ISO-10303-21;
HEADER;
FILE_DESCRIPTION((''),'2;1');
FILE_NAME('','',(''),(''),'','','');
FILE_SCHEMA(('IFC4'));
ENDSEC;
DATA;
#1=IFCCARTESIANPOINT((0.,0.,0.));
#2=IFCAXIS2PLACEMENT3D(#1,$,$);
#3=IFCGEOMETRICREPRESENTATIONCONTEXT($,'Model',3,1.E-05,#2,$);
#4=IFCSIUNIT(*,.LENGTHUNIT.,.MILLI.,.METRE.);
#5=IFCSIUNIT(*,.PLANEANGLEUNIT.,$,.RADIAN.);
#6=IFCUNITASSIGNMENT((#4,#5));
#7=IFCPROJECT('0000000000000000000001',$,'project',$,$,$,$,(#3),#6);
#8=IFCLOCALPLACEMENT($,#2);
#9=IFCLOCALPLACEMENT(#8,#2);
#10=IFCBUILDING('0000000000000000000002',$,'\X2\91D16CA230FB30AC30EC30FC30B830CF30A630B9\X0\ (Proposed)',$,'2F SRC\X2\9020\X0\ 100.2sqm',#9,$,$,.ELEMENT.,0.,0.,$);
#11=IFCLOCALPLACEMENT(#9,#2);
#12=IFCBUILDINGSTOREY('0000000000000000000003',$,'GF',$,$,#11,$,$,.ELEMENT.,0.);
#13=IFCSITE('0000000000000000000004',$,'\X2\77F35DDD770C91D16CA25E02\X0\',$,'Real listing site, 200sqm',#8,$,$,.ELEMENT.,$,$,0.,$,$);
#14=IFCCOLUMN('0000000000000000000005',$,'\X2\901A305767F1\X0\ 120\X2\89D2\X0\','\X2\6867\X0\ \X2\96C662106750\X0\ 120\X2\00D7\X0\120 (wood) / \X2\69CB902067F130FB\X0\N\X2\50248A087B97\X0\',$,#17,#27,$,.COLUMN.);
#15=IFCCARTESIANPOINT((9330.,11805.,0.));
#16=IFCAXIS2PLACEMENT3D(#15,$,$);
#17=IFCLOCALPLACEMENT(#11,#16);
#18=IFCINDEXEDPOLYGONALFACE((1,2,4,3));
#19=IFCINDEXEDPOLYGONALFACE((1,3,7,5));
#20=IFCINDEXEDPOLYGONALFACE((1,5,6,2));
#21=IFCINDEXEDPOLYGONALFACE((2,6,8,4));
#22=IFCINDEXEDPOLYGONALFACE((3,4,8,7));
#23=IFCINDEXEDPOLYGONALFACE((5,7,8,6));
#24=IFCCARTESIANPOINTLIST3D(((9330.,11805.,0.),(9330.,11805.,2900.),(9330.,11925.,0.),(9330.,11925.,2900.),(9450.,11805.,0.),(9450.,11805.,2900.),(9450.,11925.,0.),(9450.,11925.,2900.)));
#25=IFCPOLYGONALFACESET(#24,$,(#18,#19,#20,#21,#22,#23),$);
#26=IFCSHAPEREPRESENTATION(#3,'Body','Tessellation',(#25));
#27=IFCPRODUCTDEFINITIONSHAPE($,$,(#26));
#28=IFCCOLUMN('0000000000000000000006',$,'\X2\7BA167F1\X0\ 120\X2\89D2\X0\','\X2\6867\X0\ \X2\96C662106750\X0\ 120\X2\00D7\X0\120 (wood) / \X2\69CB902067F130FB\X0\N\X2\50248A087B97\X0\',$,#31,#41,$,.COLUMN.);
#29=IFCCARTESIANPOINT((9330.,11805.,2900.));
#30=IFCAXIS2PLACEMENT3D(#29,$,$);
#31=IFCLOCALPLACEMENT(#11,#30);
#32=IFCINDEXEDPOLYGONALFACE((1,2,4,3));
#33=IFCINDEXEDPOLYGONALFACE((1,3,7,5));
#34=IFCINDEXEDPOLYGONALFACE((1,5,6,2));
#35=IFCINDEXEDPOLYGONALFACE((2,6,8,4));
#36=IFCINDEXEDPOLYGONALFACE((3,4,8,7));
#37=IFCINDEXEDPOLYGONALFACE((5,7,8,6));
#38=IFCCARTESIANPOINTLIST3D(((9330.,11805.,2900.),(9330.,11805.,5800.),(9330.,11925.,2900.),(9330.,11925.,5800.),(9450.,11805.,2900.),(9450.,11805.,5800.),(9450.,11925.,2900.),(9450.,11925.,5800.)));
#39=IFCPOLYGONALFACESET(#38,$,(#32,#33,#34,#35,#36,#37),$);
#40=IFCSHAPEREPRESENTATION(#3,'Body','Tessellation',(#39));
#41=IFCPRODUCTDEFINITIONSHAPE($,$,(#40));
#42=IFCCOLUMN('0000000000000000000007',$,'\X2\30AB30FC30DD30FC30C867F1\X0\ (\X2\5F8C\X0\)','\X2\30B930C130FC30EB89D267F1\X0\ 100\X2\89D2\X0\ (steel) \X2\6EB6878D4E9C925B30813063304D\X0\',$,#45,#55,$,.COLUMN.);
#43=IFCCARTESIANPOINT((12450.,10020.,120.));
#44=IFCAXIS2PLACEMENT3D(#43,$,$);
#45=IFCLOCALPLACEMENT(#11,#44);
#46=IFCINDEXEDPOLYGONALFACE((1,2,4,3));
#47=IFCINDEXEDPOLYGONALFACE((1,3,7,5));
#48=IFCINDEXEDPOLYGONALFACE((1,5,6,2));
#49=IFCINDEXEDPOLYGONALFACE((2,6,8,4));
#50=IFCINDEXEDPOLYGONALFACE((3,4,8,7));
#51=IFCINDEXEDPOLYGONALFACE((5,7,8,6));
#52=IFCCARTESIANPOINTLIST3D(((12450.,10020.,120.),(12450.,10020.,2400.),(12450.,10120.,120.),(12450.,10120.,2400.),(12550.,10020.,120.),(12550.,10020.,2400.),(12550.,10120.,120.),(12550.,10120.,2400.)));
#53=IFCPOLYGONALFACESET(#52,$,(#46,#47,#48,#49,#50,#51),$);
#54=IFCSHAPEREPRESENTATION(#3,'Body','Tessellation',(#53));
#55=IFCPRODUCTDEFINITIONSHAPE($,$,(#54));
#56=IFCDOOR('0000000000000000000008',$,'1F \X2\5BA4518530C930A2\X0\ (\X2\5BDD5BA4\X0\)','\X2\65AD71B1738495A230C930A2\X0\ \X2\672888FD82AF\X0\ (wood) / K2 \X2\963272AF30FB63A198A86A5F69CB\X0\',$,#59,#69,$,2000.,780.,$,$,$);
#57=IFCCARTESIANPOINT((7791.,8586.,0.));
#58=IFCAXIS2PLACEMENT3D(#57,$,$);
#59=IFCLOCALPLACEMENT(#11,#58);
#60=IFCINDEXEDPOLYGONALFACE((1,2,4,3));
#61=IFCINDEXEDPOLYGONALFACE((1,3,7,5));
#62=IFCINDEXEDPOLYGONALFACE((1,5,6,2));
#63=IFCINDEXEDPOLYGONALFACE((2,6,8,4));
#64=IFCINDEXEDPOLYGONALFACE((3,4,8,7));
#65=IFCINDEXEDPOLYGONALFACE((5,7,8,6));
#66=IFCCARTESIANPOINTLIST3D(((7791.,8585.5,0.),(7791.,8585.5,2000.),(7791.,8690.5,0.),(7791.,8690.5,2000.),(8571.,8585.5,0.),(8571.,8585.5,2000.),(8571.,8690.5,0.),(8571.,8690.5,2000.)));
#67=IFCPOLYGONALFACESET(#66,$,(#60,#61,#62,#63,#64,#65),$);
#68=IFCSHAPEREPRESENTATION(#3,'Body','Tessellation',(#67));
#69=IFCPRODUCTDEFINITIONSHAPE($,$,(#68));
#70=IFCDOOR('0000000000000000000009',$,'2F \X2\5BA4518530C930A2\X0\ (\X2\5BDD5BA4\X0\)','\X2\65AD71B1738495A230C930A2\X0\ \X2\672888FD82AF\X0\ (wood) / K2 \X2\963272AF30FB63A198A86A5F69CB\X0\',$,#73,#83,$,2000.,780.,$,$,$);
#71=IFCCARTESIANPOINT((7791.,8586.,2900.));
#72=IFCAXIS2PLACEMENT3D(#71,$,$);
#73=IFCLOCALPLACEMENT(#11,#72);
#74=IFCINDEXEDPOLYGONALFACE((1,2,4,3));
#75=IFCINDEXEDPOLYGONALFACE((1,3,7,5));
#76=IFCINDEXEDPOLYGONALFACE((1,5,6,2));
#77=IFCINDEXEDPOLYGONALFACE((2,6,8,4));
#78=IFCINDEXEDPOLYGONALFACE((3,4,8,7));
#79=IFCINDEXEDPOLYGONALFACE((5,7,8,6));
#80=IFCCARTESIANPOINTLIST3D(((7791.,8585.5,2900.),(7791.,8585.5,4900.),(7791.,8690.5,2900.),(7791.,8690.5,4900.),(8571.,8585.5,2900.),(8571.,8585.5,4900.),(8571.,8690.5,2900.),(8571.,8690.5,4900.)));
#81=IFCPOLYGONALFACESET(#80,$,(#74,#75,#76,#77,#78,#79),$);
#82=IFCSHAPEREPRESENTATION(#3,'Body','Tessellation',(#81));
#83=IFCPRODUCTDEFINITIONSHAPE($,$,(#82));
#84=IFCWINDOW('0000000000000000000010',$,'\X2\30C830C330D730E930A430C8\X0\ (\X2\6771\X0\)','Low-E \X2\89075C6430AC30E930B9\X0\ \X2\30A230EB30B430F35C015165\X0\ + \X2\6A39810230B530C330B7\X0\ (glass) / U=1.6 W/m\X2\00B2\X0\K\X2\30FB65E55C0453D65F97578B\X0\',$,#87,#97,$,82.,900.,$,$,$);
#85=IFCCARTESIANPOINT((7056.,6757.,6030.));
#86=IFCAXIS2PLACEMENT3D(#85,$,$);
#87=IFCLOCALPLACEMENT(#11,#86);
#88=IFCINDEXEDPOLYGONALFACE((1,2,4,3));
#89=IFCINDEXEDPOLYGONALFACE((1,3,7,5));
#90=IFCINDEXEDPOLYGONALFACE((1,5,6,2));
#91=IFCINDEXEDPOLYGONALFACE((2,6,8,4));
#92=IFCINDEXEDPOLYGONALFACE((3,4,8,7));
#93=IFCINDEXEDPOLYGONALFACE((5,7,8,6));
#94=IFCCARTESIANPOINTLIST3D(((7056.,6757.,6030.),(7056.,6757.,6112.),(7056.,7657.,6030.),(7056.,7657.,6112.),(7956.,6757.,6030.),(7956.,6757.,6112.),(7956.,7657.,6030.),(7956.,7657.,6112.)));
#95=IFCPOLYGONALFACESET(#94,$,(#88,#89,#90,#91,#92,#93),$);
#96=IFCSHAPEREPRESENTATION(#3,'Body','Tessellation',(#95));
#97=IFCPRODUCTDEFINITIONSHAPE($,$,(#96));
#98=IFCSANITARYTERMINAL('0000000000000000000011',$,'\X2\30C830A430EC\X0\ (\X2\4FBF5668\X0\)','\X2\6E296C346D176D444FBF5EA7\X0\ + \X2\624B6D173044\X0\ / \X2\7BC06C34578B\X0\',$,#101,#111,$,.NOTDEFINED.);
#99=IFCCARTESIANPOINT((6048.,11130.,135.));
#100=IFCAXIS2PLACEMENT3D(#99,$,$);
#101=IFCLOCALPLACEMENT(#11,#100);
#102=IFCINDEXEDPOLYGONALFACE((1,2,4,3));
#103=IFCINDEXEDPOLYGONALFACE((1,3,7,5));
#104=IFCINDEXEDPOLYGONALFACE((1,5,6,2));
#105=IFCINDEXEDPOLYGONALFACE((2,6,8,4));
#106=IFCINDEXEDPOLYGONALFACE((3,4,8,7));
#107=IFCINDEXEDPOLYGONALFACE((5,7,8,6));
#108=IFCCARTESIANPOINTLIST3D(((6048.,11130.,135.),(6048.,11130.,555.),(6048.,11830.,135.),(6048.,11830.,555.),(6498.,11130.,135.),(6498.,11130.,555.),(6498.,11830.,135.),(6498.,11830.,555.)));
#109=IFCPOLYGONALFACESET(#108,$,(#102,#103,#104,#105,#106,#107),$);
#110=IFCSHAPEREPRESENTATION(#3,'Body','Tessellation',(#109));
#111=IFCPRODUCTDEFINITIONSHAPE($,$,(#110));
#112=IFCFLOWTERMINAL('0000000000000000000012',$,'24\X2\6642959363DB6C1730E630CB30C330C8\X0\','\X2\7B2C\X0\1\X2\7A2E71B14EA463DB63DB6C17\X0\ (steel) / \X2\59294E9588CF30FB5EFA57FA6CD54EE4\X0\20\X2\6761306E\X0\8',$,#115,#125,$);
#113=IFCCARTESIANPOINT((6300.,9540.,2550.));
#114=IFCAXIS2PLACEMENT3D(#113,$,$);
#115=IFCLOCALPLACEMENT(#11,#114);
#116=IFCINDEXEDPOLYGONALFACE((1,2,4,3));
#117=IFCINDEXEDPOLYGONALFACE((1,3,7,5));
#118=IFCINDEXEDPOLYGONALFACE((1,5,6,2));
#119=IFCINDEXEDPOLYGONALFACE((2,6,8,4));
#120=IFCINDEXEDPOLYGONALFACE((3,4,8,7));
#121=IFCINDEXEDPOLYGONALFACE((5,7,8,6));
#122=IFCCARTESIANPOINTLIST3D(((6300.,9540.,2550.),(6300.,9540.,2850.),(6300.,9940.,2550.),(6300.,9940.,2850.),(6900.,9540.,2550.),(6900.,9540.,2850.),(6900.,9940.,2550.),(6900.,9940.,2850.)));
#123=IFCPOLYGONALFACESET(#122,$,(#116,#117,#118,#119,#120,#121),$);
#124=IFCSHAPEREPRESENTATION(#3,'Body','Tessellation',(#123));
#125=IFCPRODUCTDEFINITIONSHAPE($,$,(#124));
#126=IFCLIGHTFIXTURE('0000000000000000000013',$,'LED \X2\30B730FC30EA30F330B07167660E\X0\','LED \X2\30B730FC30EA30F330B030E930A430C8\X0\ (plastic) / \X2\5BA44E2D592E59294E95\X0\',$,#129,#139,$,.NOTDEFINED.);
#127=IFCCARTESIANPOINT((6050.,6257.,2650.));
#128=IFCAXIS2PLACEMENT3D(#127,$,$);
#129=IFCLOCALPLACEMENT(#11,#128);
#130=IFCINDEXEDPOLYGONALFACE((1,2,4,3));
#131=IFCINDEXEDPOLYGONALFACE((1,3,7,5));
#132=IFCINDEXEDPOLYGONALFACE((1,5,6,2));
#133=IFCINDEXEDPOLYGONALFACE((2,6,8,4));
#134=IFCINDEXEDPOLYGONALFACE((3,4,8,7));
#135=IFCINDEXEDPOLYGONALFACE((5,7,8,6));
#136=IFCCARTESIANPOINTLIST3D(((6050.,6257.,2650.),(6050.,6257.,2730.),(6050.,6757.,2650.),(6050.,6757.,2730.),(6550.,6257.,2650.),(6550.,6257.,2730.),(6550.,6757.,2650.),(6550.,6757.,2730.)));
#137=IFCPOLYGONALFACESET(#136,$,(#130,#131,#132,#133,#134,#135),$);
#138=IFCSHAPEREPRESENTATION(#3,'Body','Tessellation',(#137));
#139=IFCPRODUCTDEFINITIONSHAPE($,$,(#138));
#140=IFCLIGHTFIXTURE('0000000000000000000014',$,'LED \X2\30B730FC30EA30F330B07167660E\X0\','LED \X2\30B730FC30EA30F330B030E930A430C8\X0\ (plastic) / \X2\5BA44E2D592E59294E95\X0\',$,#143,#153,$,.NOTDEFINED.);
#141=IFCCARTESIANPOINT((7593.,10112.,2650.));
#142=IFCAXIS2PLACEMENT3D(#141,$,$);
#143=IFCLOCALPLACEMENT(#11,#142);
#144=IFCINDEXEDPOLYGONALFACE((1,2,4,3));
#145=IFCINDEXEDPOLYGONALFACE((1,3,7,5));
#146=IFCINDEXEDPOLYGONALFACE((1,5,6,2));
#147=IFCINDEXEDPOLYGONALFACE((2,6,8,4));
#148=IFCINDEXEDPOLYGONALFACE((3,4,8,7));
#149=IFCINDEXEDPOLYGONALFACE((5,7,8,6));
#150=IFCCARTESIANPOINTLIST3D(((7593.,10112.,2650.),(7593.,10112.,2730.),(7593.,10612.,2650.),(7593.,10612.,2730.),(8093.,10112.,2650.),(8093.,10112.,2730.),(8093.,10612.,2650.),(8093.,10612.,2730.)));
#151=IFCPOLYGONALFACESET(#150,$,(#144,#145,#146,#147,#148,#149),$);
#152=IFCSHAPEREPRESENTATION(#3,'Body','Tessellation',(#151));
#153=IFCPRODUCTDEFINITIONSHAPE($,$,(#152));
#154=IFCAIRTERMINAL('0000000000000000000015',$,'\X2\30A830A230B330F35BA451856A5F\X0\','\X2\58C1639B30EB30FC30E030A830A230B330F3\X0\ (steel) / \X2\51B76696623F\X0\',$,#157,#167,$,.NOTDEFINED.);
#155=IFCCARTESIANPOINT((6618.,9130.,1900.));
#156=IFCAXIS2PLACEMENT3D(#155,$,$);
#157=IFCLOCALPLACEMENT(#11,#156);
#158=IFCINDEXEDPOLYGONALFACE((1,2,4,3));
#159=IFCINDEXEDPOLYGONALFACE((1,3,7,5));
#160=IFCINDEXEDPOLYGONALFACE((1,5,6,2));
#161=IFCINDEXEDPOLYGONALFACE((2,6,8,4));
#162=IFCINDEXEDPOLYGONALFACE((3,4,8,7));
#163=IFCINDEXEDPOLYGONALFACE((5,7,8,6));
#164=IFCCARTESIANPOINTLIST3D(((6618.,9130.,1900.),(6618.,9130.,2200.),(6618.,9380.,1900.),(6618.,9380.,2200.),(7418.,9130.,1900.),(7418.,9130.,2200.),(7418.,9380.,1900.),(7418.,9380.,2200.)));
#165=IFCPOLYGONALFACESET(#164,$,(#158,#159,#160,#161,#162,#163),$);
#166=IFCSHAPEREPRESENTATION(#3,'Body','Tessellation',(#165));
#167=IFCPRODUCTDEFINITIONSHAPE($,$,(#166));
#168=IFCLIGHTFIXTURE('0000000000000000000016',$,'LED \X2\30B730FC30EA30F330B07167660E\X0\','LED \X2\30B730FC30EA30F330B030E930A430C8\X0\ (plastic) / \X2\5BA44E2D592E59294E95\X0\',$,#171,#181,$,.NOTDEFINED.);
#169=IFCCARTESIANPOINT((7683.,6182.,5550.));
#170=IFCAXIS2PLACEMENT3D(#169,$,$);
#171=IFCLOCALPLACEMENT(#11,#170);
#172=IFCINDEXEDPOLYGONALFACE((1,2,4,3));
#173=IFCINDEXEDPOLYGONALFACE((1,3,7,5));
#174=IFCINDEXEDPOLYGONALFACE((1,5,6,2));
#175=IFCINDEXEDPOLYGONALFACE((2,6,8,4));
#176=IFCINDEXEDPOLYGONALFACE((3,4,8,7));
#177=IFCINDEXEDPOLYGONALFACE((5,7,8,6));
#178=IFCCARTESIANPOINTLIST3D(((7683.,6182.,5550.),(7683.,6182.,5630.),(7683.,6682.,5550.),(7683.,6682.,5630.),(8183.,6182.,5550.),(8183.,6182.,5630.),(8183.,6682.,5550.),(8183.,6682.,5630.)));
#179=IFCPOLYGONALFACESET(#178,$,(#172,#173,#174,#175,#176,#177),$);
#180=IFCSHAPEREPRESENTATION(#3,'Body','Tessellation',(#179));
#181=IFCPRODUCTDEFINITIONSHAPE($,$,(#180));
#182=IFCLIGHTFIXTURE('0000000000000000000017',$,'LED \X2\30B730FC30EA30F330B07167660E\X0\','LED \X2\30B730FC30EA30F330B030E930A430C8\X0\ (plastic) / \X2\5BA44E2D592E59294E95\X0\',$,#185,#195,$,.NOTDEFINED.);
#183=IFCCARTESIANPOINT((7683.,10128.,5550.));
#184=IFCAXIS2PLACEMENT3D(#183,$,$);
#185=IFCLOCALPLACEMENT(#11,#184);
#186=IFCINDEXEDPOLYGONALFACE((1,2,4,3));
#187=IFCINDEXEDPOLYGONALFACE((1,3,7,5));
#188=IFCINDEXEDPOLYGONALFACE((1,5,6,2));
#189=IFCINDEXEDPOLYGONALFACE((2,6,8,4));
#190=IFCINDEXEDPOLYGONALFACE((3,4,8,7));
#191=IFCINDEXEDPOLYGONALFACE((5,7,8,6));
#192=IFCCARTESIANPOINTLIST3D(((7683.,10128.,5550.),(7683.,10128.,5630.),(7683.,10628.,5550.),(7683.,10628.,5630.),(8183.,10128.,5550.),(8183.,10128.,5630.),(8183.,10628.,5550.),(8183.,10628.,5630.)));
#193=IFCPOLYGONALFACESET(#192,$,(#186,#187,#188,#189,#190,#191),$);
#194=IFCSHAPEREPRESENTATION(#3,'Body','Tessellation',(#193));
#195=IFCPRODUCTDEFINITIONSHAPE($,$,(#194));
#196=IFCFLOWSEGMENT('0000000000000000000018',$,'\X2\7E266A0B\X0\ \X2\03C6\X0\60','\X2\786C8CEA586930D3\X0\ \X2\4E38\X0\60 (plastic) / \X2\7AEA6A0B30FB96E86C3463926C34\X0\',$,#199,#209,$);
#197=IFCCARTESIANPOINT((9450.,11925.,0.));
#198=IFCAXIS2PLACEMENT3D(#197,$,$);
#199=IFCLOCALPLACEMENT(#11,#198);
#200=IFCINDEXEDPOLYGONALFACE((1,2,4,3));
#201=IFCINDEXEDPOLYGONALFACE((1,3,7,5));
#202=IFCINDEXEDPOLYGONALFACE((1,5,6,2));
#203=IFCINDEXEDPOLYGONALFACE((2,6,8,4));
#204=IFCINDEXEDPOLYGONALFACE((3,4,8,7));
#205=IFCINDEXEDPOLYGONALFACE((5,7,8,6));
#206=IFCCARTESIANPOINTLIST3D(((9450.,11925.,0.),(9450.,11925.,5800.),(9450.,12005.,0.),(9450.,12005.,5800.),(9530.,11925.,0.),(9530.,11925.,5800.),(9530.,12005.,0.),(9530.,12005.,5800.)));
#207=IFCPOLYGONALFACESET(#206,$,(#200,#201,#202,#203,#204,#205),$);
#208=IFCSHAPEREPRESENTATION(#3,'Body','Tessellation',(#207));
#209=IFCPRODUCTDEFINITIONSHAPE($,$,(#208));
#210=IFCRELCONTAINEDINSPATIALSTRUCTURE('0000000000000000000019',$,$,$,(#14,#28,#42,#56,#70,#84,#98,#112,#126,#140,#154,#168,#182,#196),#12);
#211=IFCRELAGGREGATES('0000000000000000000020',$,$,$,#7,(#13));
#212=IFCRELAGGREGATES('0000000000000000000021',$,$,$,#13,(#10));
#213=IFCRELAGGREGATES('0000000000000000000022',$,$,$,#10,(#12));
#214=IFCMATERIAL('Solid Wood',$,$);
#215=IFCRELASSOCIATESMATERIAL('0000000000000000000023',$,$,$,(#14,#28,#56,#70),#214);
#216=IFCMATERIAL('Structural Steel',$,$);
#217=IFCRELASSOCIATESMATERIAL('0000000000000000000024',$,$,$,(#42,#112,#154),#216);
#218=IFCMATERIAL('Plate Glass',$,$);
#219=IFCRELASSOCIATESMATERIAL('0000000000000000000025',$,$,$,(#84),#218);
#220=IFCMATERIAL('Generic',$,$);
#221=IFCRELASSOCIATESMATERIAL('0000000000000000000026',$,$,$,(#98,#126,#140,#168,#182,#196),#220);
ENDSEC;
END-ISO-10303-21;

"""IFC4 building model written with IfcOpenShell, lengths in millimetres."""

from ifc_helpers import new_model, si_unit, frame, frame_2d, origin, place, context, project, spatial, rectangle, extrude, material, element, save


model = new_model("IFC4")

# Units and contexts
model_context = context("Model", 3, precision=1e-05, world=origin())
ifc_project = project(units=[si_unit("LENGTHUNIT", "METRE", prefix="MILLI"), si_unit("PLANEANGLEUNIT", "RADIAN")], contexts=[model_context])

# Site, building, storey
site_placement = place(None, origin())
site = spatial("IfcSite", under=ifc_project, at=site_placement, Name="石川県金沢市", ObjectType="Real listing site, 200sqm", CompositionType="ELEMENT", RefElevation=0.0)
building_placement = place(site_placement, origin())
building = spatial("IfcBuilding", under=site, at=building_placement, Name="金沢・ガレージハウス (Proposed)", ObjectType="2F SRC造 100.2sqm", CompositionType="ELEMENT", ElevationOfRefHeight=0.0, ElevationOfTerrain=0.0)
storey_placement = place(building_placement, origin())
storey = spatial("IfcBuildingStorey", under=building, at=storey_placement, Name="GF", CompositionType="ELEMENT", Elevation=0.0)

# Columns
ifc_material_1 = material(Name="Solid Wood")
column_1_placement = place(storey_placement, frame((9330.0, 11805.0, 0.0)))
element("IfcColumn", 1, at=column_1_placement, inside=storey, material=ifc_material_1, Name="通し柱 120角", Description="桧 集成材 120×120 (wood) / 構造柱・N値計算", PredefinedType="COLUMN", context=model_context, shape_type="SweptSolid", body=[
    extrude(rectangle(XDim=120.0, YDim=120.0, at=frame_2d((60.0, 60.0))), frame((9330.0, 11805.0, 0.0)), (0.0, 0.0, 1.0), 2900.0),
])
column_2_placement = place(storey_placement, frame((9330.0, 11805.0, 2900.0)))
element("IfcColumn", 2, at=column_2_placement, inside=storey, material=ifc_material_1, Name="管柱 120角", Description="桧 集成材 120×120 (wood) / 構造柱・N値計算", PredefinedType="COLUMN", context=model_context, shape_type="SweptSolid", body=[
    extrude(rectangle(XDim=120.0, YDim=120.0, at=frame_2d((60.0, 60.0))), frame((9330.0, 11805.0, 2900.0)), (0.0, 0.0, 1.0), 2900.0),
])
ifc_material_2 = material(Name="Structural Steel")
column_3_placement = place(storey_placement, frame((12450.0, 10020.0, 120.0)))
element("IfcColumn", 3, at=column_3_placement, inside=storey, material=ifc_material_2, Name="カーポート柱 (後)", Description="スチール角柱 100角 (steel) 溶融亜鉛めっき", PredefinedType="COLUMN", context=model_context, shape_type="SweptSolid", body=[
    extrude(rectangle(XDim=100.0, YDim=100.0, at=frame_2d((50.0, 50.0))), frame((12450.0, 10020.0, 120.0)), (0.0, 0.0, 1.0), 2280.0),
])

# Door
door_1_placement = place(storey_placement, frame((7791.0, 8586.0, 0.0)))
element("IfcDoor", 4, at=door_1_placement, inside=storey, material=ifc_material_1, Name="1F 室内ドア (寝室)", Description="断熱玄関ドア 木製芯 (wood) / K2 防犯・採風機構", OverallHeight=2000.0, OverallWidth=780.0, context=model_context, shape_type="SweptSolid", body=[
    extrude(rectangle(XDim=780.0, YDim=105.0, at=frame_2d((390.0, 52.0))), frame((7791.0, 8586.0, 0.0)), (0.0, 0.0, 1.0), 2000.0),
])

# Door
door_2_placement = place(storey_placement, frame((7791.0, 8586.0, 2900.0)))
element("IfcDoor", 5, at=door_2_placement, inside=storey, material=ifc_material_1, Name="2F 室内ドア (寝室)", Description="断熱玄関ドア 木製芯 (wood) / K2 防犯・採風機構", OverallHeight=2000.0, OverallWidth=780.0, context=model_context, shape_type="SweptSolid", body=[
    extrude(rectangle(XDim=780.0, YDim=105.0, at=frame_2d((390.0, 52.0))), frame((7791.0, 8586.0, 2900.0)), (0.0, 0.0, 1.0), 2000.0),
])

# Window
ifc_material_3 = material(Name="Plate Glass")
window_placement = place(storey_placement, frame((7056.0, 6757.0, 6030.0)))
element("IfcWindow", 6, at=window_placement, inside=storey, material=ifc_material_3, Name="トップライト (東)", Description="Low-E 複層ガラス アルゴン封入 + 樹脂サッシ (glass) / U=1.6 W/m²K・日射取得型", OverallHeight=82.0, OverallWidth=900.0, context=model_context, shape_type="SweptSolid", body=[
    extrude(rectangle(XDim=900.0, YDim=900.0, at=frame_2d((450.0, 450.0))), frame((7056.0, 6757.0, 6030.0)), (0.0, 0.0, 1.0), 82.0),
])

# Sanitary terminal
ifc_material_4 = material(Name="Generic")
sanitary_terminal_placement = place(storey_placement, frame((6048.0, 11130.0, 135.0)))
element("IfcSanitaryTerminal", 7, at=sanitary_terminal_placement, inside=storey, material=ifc_material_4, Name="トイレ (便器)", Description="温水洗浄便座 + 手洗い / 節水型", PredefinedType="NOTDEFINED", context=model_context, shape_type="SweptSolid", body=[
    extrude(rectangle(XDim=450.0, YDim=700.0, at=frame_2d((225.0, 350.0))), frame((6048.0, 11130.0, 135.0)), (0.0, 0.0, 1.0), 420.0),
])

# Flow terminal
flow_terminal_placement = place(storey_placement, frame((6300.0, 9540.0, 2550.0)))
element("IfcFlowTerminal", 8, at=flow_terminal_placement, inside=storey, material=ifc_material_2, Name="24時間換気ユニット", Description="第1種熱交換換気 (steel) / 天井裏・建基法令20条の8", context=model_context, shape_type="SweptSolid", body=[
    extrude(rectangle(XDim=600.0, YDim=400.0, at=frame_2d((300.0, 200.0))), frame((6300.0, 9540.0, 2550.0)), (0.0, 0.0, 1.0), 300.0),
])

# Light fixtures
light_fixture_1_placement = place(storey_placement, frame((6050.0, 6257.0, 2650.0)))
element("IfcLightFixture", 9, at=light_fixture_1_placement, inside=storey, material=ifc_material_4, Name="LED シーリング照明", Description="LED シーリングライト (plastic) / 室中央天井", PredefinedType="NOTDEFINED", context=model_context, shape_type="SweptSolid", body=[
    extrude(rectangle(XDim=500.0, YDim=500.0, at=frame_2d((250.0, 250.0))), frame((6050.0, 6257.0, 2650.0)), (0.0, 0.0, 1.0), 80.0),
])
light_fixture_2_placement = place(storey_placement, frame((7593.0, 10112.0, 2650.0)))
element("IfcLightFixture", 10, at=light_fixture_2_placement, inside=storey, material=ifc_material_4, Name="LED シーリング照明", Description="LED シーリングライト (plastic) / 室中央天井", PredefinedType="NOTDEFINED", context=model_context, shape_type="SweptSolid", body=[
    extrude(rectangle(XDim=500.0, YDim=500.0, at=frame_2d((250.0, 250.0))), frame((7593.0, 10112.0, 2650.0)), (0.0, 0.0, 1.0), 80.0),
])

# Air terminal
air_terminal_placement = place(storey_placement, frame((6618.0, 9130.0, 1900.0)))
element("IfcAirTerminal", 11, at=air_terminal_placement, inside=storey, material=ifc_material_2, Name="エアコン室内機", Description="壁掛ルームエアコン (steel) / 冷暖房", PredefinedType="NOTDEFINED", context=model_context, shape_type="SweptSolid", body=[
    extrude(rectangle(XDim=800.0, YDim=250.0, at=frame_2d((400.0, 125.0))), frame((6618.0, 9130.0, 1900.0)), (0.0, 0.0, 1.0), 300.0),
])

# Light fixtures
light_fixture_3_placement = place(storey_placement, frame((7683.0, 6182.0, 5550.0)))
element("IfcLightFixture", 12, at=light_fixture_3_placement, inside=storey, material=ifc_material_4, Name="LED シーリング照明", Description="LED シーリングライト (plastic) / 室中央天井", PredefinedType="NOTDEFINED", context=model_context, shape_type="SweptSolid", body=[
    extrude(rectangle(XDim=500.0, YDim=500.0, at=frame_2d((250.0, 250.0))), frame((7683.0, 6182.0, 5550.0)), (0.0, 0.0, 1.0), 80.0),
])
light_fixture_4_placement = place(storey_placement, frame((7683.0, 10128.0, 5550.0)))
element("IfcLightFixture", 13, at=light_fixture_4_placement, inside=storey, material=ifc_material_4, Name="LED シーリング照明", Description="LED シーリングライト (plastic) / 室中央天井", PredefinedType="NOTDEFINED", context=model_context, shape_type="SweptSolid", body=[
    extrude(rectangle(XDim=500.0, YDim=500.0, at=frame_2d((250.0, 250.0))), frame((7683.0, 10128.0, 5550.0)), (0.0, 0.0, 1.0), 80.0),
])

# Flow segment
flow_segment_placement = place(storey_placement, frame((9450.0, 11925.0, 0.0)))
element("IfcFlowSegment", 14, at=flow_segment_placement, inside=storey, material=ifc_material_4, Name="縦樋 φ60", Description="硬質塩ビ 丸60 (plastic) / 竪樋・雨水排水", context=model_context, shape_type="SweptSolid", body=[
    extrude(rectangle(XDim=80.0, YDim=80.0, at=frame_2d((40.0, 40.0))), frame((9450.0, 11925.0, 0.0)), (0.0, 0.0, 1.0), 5800.0),
])

save(model, "model.ifc")
